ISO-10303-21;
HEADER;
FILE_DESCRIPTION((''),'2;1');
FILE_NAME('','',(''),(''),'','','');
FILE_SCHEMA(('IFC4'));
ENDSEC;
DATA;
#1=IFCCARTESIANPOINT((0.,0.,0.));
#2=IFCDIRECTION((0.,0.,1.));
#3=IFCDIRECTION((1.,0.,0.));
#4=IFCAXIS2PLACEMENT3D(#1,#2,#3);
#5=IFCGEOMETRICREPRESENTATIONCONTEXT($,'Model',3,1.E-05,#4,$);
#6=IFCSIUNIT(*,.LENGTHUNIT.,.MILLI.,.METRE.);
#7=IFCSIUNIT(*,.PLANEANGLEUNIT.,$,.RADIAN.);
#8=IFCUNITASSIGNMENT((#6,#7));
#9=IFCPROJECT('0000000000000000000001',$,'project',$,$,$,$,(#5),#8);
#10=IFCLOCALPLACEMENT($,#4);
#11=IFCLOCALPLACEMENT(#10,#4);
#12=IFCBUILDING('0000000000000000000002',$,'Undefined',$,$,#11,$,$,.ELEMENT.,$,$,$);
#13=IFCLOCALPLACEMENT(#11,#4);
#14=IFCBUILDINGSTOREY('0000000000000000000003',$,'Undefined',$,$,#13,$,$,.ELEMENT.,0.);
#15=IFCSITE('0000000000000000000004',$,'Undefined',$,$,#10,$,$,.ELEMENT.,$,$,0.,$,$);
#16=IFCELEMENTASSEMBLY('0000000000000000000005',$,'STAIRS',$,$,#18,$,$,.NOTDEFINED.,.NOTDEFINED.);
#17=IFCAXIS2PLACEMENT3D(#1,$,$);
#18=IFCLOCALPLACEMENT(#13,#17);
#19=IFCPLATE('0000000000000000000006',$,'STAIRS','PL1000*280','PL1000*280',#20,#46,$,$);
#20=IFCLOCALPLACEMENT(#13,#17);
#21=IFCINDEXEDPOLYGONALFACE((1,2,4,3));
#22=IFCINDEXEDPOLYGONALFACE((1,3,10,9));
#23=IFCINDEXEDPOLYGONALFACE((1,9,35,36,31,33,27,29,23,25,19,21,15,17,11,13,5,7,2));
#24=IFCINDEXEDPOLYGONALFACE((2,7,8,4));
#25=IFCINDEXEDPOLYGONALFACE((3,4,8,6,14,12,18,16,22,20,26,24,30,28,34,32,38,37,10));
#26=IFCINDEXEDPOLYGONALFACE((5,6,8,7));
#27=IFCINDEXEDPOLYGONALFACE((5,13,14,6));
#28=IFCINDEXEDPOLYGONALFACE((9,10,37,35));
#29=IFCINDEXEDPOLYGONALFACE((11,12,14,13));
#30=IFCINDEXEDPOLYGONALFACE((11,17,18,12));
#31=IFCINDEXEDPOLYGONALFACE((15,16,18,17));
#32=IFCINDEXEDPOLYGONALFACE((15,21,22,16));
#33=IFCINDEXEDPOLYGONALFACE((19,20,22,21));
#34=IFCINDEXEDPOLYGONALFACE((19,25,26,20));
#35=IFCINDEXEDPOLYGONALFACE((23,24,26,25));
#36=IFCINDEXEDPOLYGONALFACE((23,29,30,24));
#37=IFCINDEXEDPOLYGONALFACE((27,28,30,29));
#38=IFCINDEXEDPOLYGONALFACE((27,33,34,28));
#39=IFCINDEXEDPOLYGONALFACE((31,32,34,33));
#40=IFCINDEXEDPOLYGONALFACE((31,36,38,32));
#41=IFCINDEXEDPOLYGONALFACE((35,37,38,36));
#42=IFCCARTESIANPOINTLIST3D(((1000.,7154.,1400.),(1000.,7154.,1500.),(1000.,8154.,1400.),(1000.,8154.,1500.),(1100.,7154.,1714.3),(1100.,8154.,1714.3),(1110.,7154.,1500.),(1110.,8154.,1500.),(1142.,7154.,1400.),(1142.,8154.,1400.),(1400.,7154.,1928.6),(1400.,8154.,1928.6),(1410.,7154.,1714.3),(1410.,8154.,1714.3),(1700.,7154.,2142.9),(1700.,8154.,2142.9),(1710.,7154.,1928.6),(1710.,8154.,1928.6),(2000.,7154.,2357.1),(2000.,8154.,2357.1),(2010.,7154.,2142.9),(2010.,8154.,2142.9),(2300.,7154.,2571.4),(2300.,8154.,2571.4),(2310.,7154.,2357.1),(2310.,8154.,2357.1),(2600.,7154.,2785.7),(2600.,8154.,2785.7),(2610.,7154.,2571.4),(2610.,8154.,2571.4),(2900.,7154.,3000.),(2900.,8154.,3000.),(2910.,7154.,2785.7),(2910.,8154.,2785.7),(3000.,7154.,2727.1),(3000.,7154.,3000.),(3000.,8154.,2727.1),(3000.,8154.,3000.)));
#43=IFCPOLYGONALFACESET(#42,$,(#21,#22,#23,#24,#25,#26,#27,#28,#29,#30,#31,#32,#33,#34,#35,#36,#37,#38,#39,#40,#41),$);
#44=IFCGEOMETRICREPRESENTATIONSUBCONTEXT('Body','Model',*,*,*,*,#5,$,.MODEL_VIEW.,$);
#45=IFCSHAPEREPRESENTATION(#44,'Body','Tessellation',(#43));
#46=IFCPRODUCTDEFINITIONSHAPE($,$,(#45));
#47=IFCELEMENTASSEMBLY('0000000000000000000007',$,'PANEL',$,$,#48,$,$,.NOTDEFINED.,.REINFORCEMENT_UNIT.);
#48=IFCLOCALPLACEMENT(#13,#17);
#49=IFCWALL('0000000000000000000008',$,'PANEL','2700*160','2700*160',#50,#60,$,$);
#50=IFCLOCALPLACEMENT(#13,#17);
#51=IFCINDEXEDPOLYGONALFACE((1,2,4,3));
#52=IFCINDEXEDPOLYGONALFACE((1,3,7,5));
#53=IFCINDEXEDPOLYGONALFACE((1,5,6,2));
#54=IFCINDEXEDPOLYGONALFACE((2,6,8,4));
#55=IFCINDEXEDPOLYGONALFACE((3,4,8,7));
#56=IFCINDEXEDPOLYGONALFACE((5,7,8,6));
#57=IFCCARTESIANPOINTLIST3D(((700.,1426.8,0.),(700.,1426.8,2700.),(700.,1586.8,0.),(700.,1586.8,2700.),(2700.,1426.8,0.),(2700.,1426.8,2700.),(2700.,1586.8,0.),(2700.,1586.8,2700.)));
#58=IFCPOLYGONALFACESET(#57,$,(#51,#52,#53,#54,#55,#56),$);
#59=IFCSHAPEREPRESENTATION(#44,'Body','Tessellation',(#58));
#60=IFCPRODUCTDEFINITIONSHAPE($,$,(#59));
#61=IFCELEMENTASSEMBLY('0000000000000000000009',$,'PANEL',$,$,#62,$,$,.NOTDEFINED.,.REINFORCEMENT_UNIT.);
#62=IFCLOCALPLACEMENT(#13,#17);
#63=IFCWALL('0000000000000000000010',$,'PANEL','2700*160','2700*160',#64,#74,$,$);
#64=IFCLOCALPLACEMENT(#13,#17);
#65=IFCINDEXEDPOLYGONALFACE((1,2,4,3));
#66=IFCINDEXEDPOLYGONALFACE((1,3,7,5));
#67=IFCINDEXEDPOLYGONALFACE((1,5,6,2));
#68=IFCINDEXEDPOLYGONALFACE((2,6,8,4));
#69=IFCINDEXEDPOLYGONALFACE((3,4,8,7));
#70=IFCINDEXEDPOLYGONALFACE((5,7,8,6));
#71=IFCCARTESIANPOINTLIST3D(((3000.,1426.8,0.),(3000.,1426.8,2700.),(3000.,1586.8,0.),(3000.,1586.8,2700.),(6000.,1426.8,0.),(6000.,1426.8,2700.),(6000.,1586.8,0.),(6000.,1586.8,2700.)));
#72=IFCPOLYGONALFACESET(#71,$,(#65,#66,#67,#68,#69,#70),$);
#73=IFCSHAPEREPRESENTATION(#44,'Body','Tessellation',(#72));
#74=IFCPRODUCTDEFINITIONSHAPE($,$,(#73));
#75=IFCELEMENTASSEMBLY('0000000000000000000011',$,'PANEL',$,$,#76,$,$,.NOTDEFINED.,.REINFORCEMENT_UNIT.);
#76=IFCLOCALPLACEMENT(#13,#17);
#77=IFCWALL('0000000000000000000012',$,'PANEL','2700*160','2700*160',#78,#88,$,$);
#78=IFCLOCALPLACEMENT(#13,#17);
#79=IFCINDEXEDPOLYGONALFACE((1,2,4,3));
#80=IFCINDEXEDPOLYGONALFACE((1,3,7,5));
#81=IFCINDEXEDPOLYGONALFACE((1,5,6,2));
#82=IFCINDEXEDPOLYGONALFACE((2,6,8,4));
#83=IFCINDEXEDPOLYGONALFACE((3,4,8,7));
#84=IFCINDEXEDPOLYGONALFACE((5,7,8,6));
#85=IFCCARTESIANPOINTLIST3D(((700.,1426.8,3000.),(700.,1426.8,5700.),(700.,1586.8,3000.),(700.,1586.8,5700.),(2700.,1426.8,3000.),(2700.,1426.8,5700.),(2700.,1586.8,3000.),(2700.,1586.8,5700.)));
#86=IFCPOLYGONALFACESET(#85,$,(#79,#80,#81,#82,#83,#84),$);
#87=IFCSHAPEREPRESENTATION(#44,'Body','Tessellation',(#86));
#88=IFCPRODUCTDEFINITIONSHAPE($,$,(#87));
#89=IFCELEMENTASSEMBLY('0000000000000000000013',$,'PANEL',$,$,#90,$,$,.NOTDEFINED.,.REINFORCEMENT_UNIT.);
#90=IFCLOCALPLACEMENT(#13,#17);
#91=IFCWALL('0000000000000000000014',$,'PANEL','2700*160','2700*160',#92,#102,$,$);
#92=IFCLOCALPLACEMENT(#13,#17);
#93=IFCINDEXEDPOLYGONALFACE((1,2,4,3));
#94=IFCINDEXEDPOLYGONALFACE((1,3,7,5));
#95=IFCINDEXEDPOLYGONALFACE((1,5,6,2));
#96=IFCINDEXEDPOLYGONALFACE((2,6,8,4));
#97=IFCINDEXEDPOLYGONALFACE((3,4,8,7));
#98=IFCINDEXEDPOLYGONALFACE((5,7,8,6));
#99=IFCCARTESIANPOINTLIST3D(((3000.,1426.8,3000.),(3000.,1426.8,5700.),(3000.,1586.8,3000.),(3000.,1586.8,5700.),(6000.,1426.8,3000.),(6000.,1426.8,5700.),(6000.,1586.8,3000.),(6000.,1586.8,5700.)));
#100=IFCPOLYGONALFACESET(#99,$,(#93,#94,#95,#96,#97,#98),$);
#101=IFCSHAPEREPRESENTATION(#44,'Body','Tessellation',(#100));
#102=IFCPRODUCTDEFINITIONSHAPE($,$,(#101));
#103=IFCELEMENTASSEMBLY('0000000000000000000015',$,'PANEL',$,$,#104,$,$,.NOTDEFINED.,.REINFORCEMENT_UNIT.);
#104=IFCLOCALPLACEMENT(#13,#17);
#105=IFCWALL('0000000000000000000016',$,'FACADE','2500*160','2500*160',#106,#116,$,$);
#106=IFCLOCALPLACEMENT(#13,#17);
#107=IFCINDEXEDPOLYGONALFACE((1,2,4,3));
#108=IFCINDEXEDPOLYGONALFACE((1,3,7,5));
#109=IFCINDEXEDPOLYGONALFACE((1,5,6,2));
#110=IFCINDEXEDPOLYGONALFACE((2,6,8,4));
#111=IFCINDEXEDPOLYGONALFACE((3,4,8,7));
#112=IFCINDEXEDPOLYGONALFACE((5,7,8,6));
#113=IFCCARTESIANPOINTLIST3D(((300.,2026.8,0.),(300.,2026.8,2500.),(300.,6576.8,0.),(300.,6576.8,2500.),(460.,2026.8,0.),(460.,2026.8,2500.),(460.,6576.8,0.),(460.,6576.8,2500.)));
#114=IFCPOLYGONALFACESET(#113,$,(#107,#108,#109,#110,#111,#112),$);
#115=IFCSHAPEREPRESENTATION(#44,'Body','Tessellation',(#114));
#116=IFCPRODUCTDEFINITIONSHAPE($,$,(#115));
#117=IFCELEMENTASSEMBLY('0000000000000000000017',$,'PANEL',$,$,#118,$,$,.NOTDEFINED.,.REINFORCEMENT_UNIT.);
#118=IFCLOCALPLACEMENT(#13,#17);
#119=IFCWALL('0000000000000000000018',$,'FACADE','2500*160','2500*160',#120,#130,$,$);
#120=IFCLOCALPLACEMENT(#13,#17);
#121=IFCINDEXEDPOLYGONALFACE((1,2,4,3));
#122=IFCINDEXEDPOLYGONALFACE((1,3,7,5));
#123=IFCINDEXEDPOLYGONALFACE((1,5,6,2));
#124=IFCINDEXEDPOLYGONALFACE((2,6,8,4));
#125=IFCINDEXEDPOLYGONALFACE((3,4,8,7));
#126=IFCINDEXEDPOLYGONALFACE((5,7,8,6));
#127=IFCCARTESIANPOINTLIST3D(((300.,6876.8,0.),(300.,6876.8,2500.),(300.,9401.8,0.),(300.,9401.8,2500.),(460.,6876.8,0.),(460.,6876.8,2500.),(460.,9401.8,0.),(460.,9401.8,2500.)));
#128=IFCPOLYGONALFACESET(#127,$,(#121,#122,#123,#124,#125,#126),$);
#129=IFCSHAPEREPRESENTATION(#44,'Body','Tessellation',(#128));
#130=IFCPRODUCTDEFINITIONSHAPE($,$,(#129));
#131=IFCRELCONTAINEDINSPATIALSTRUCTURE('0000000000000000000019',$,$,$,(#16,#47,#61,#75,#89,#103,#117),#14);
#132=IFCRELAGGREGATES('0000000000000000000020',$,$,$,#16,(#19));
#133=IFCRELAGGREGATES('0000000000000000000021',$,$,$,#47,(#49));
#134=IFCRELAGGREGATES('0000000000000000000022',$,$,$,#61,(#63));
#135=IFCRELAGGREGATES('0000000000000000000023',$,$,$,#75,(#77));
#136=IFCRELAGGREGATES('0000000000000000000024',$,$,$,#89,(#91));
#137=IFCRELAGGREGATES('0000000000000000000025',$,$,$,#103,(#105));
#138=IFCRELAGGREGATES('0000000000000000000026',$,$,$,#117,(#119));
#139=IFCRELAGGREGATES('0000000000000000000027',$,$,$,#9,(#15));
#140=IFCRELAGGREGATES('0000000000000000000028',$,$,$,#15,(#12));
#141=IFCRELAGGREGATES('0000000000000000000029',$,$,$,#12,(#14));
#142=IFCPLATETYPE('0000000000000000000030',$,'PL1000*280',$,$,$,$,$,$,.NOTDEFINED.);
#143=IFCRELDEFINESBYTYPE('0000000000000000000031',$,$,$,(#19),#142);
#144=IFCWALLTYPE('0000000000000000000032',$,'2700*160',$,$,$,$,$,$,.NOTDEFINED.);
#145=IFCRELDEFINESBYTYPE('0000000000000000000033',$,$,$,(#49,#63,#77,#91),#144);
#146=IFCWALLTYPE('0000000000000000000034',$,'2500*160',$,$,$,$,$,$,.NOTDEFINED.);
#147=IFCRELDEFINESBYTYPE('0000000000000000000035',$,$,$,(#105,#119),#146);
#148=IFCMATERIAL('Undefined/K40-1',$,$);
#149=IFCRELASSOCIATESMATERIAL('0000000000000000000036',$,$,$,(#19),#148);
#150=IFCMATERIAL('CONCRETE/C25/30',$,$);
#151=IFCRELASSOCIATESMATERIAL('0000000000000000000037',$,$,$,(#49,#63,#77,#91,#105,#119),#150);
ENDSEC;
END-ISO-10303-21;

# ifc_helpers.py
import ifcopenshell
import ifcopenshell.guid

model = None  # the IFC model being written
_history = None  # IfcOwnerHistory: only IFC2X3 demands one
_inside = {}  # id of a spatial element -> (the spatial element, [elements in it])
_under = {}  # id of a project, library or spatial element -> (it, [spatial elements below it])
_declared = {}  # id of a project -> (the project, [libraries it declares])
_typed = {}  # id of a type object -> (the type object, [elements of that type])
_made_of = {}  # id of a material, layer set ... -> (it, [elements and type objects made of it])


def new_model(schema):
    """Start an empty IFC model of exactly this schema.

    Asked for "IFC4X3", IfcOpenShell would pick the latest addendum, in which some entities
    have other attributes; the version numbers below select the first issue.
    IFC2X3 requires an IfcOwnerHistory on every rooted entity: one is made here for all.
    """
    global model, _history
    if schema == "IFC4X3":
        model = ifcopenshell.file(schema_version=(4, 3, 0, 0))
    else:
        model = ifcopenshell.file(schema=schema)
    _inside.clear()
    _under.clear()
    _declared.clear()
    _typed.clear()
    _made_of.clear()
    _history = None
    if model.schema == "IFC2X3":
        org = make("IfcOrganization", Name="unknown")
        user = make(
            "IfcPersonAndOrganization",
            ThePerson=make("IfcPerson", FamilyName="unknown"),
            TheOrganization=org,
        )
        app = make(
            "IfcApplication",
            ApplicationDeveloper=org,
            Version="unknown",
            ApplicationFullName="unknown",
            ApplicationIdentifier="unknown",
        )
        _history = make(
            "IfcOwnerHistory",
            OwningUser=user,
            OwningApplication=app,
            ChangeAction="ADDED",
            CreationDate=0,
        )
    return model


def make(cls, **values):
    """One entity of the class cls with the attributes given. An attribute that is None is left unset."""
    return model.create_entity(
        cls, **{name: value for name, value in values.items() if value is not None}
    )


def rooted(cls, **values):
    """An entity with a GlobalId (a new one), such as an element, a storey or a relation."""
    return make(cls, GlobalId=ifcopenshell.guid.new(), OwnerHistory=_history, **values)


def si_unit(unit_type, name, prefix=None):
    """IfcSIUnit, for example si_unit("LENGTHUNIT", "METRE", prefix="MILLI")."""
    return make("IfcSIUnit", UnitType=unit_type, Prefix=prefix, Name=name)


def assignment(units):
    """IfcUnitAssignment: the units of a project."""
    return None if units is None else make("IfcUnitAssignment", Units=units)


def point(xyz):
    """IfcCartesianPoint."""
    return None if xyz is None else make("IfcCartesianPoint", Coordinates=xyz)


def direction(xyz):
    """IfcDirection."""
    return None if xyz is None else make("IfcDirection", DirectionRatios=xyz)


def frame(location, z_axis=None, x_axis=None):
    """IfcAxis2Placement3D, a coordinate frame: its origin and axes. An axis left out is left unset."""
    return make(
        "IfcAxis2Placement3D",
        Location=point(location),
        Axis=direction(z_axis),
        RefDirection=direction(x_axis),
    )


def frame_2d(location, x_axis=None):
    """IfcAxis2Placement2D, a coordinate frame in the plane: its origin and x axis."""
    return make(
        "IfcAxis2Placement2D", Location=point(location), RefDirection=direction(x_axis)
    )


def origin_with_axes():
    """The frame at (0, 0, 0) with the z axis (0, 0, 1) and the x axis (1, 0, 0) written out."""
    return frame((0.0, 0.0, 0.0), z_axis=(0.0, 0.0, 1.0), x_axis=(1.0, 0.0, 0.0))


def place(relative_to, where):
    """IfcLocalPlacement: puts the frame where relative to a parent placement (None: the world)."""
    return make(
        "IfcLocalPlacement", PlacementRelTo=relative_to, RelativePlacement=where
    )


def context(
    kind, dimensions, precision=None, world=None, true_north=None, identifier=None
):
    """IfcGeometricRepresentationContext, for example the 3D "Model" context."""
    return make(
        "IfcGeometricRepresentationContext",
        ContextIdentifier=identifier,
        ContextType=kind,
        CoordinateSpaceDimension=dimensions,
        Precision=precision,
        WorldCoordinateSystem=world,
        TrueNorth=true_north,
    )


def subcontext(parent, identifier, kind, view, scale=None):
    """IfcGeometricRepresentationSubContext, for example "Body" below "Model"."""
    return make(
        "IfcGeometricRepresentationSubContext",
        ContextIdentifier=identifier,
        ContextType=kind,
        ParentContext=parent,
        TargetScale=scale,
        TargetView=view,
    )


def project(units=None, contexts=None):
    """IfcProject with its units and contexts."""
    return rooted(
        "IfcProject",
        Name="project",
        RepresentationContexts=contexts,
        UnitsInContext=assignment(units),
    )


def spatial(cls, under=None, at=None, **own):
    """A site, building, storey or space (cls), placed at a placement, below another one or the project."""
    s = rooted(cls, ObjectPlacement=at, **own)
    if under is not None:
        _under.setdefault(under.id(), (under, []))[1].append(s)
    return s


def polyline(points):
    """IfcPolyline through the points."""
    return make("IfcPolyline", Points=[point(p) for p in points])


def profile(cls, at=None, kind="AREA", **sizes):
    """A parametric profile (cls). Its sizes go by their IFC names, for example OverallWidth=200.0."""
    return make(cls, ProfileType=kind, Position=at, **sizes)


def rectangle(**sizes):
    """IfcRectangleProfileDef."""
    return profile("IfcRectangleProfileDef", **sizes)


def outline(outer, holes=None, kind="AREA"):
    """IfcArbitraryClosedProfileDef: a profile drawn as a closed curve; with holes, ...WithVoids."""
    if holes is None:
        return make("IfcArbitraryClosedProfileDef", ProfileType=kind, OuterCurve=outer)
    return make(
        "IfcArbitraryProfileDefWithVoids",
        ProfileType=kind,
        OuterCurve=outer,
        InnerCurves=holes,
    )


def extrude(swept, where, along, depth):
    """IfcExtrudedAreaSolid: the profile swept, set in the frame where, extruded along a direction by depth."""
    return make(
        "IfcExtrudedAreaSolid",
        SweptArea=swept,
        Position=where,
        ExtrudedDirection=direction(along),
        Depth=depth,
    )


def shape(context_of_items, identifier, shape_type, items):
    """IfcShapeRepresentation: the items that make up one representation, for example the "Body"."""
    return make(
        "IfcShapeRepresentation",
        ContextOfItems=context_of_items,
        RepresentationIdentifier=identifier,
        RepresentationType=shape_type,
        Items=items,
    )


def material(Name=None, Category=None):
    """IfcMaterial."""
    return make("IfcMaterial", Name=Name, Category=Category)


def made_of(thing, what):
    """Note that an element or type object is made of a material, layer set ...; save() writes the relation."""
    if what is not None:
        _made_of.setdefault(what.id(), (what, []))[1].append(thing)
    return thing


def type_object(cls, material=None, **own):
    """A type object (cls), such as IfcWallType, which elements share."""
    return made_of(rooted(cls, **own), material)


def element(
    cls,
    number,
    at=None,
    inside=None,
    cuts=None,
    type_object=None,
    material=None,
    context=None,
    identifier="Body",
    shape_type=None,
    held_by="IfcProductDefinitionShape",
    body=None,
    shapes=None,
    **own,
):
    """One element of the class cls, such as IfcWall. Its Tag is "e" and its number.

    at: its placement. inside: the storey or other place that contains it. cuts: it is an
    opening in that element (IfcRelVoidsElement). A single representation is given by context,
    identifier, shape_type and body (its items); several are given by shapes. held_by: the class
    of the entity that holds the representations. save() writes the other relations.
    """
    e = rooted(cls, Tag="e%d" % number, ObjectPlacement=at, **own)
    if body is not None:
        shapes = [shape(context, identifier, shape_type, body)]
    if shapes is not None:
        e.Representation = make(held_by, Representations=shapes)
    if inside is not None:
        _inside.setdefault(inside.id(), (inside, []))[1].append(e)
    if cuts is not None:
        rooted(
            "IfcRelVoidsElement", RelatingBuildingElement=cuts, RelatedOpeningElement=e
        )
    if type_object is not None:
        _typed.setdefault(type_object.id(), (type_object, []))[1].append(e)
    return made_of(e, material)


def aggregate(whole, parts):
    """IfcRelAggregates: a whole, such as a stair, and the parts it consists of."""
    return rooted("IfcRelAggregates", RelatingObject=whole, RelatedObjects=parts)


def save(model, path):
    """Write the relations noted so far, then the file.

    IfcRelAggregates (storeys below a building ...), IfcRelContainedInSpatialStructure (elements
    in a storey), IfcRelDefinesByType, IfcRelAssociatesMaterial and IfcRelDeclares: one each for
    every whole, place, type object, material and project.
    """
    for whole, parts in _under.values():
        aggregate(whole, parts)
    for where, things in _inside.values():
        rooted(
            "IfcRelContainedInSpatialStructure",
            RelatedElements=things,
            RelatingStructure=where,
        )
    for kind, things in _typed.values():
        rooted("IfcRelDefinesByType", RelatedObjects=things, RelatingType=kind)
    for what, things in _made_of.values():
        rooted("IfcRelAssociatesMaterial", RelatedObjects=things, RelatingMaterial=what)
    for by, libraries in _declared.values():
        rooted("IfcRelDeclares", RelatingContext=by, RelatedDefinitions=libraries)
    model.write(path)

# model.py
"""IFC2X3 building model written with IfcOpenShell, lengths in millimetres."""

from ifc_helpers import new_model, si_unit, frame, frame_2d, origin_with_axes, place, context, subcontext, project, spatial, polyline, rectangle, outline, extrude, material, type_object, element, aggregate, save


model = new_model("IFC2X3")

# Units and contexts
model_context = context("Model", 3, precision=1e-05, world=origin_with_axes())
body_context = subcontext(model_context, "Body", "Model", "MODEL_VIEW")
ifc_project = project(units=[si_unit("LENGTHUNIT", "METRE", prefix="MILLI"), si_unit("PLANEANGLEUNIT", "RADIAN")], contexts=[model_context])

# Site, building, storey
site_placement = place(None, origin_with_axes())
site = spatial("IfcSite", under=ifc_project, at=site_placement, Name="Undefined", CompositionType="ELEMENT", RefElevation=0.0)
building_placement = place(site_placement, origin_with_axes())
building = spatial("IfcBuilding", under=site, at=building_placement, Name="Undefined", CompositionType="ELEMENT")
storey_placement = place(building_placement, origin_with_axes())
storey = spatial("IfcBuildingStorey", under=building, at=storey_placement, Name="Undefined", CompositionType="ELEMENT", Elevation=0.0)

# Shared definitions
ifc_material_1 = material(Name="CONCRETE/C25/30")

# Element assembly, plate
ifc_material_2 = material(Name="Undefined/K40-1")
assembly_1_placement = place(storey_placement, origin_with_axes())
assembly_1 = element("IfcElementAssembly", 1, at=assembly_1_placement, inside=storey, Name="STAIRS", AssemblyPlace="NOTDEFINED", PredefinedType="NOTDEFINED")
plate_type_1 = type_object("IfcPlateType", Name="PL1000*280", PredefinedType="NOTDEFINED")
plate_1_placement = place(assembly_1_placement, frame((1110.0, 7654.0, 1500.0), z_axis=(0.0, -1.0, 0.0), x_axis=(-1.0, 0.0, 0.0)))
plate_1 = element("IfcPlate", 2, at=plate_1_placement, type_object=plate_type_1, material=ifc_material_2, Name="STAIRS", Description="PL1000*280", ObjectType="PL1000*280", context=body_context, shape_type="SweptSolid", body=[
    extrude(outline(polyline([(0.0, 0.0), (110.0, 0.0), (110.0, 100.0), (-32.0, 100.0), (-1890.0, -1227.1), (-1890.0, -1500.0), (-1790.0, -1500.0), (-1800.0, -1285.7), (-1490.0, -1285.7), (-1500.0, -1071.4), (-1190.0, -1071.4), (-1200.0, -857.1), (-890.0, -857.1), (-900.0, -642.9), (-590.0, -642.9), (-600.0, -428.6), (-290.0, -428.6), (-300.0, -214.3), (10.0, -214.3), (0.0, 0.0), (0.0, 0.0)])), frame((0.0, 0.0, -500.0), z_axis=(0.0, 0.0, 1.0), x_axis=(1.0, 0.0, 0.0)), (0.0, 0.0, 1.0), 1000.0),
])
aggregate(assembly_1, [plate_1])

# Element assemblies, walls
assembly_2_placement = place(storey_placement, origin_with_axes())
assembly_2 = element("IfcElementAssembly", 3, at=assembly_2_placement, inside=storey, Name="PANEL", AssemblyPlace="NOTDEFINED", PredefinedType="REINFORCEMENT_UNIT")
wall_type_1 = type_object("IfcWallType", Name="2700*160", PredefinedType="NOTDEFINED")
wall_1_placement = place(assembly_2_placement, frame((700.0, 1506.8, 0.0), z_axis=(0.0, 0.0, 1.0), x_axis=(1.0, 0.0, 0.0)))
wall_1 = element("IfcWall", 4, at=wall_1_placement, type_object=wall_type_1, material=ifc_material_1, Name="PANEL", Description="2700*160", ObjectType="2700*160", context=body_context, shape_type="SweptSolid", body=[
    extrude(rectangle(XDim=2000.0, YDim=160.0, at=frame_2d((0.0, 1000.0), x_axis=(0.0, -1.0))), frame((0.0, 0.0, 0.0), z_axis=(0.0, 0.0, 1.0), x_axis=(0.0, -1.0, 0.0)), (0.0, 0.0, 1.0), 2700.0),
])
aggregate(assembly_2, [wall_1])
assembly_3_placement = place(storey_placement, origin_with_axes())
assembly_3 = element("IfcElementAssembly", 5, at=assembly_3_placement, inside=storey, Name="PANEL", AssemblyPlace="NOTDEFINED", PredefinedType="REINFORCEMENT_UNIT")
wall_2_placement = place(assembly_3_placement, frame((3000.0, 1506.8, 0.0), z_axis=(0.0, 0.0, 1.0), x_axis=(1.0, 0.0, 0.0)))
wall_2 = element("IfcWall", 6, at=wall_2_placement, type_object=wall_type_1, material=ifc_material_1, Name="PANEL", Description="2700*160", ObjectType="2700*160", context=body_context, shape_type="SweptSolid", body=[
    extrude(rectangle(XDim=3000.0, YDim=160.0, at=frame_2d((0.0, 1500.0), x_axis=(0.0, -1.0))), frame((0.0, 0.0, 0.0), z_axis=(0.0, 0.0, 1.0), x_axis=(0.0, -1.0, 0.0)), (0.0, 0.0, 1.0), 2700.0),
])
aggregate(assembly_3, [wall_2])
assembly_4_placement = place(storey_placement, origin_with_axes())
assembly_4 = element("IfcElementAssembly", 7, at=assembly_4_placement, inside=storey, Name="PANEL", AssemblyPlace="NOTDEFINED", PredefinedType="REINFORCEMENT_UNIT")
wall_3_placement = place(assembly_4_placement, frame((700.0, 1506.8, 3000.0), z_axis=(0.0, 0.0, 1.0), x_axis=(1.0, 0.0, 0.0)))
wall_3 = element("IfcWall", 8, at=wall_3_placement, type_object=wall_type_1, material=ifc_material_1, Name="PANEL", Description="2700*160", ObjectType="2700*160", context=body_context, shape_type="SweptSolid", body=[
    extrude(rectangle(XDim=2000.0, YDim=160.0, at=frame_2d((0.0, 1000.0), x_axis=(0.0, -1.0))), frame((0.0, 0.0, 0.0), z_axis=(0.0, 0.0, 1.0), x_axis=(0.0, -1.0, 0.0)), (0.0, 0.0, 1.0), 2700.0),
])
aggregate(assembly_4, [wall_3])
assembly_5_placement = place(storey_placement, origin_with_axes())
assembly_5 = element("IfcElementAssembly", 9, at=assembly_5_placement, inside=storey, Name="PANEL", AssemblyPlace="NOTDEFINED", PredefinedType="REINFORCEMENT_UNIT")
wall_4_placement = place(assembly_5_placement, frame((3000.0, 1506.8, 3000.0), z_axis=(0.0, 0.0, 1.0), x_axis=(1.0, 0.0, 0.0)))
wall_4 = element("IfcWall", 10, at=wall_4_placement, type_object=wall_type_1, material=ifc_material_1, Name="PANEL", Description="2700*160", ObjectType="2700*160", context=body_context, shape_type="SweptSolid", body=[
    extrude(rectangle(XDim=3000.0, YDim=160.0, at=frame_2d((0.0, 1500.0), x_axis=(0.0, -1.0))), frame((0.0, 0.0, 0.0), z_axis=(0.0, 0.0, 1.0), x_axis=(0.0, -1.0, 0.0)), (0.0, 0.0, 1.0), 2700.0),
])
aggregate(assembly_5, [wall_4])
assembly_6_placement = place(storey_placement, origin_with_axes())
assembly_6 = element("IfcElementAssembly", 11, at=assembly_6_placement, inside=storey, Name="PANEL", AssemblyPlace="NOTDEFINED", PredefinedType="REINFORCEMENT_UNIT")
wall_type_2 = type_object("IfcWallType", Name="2500*160", PredefinedType="NOTDEFINED")
wall_5_placement = place(assembly_6_placement, frame((380.0, 6576.8, 0.0), z_axis=(0.0, 0.0, 1.0), x_axis=(0.0, -1.0, 0.0)))
wall_5 = element("IfcWall", 12, at=wall_5_placement, type_object=wall_type_2, material=ifc_material_1, Name="FACADE", Description="2500*160", ObjectType="2500*160", context=body_context, shape_type="SweptSolid", body=[
    extrude(rectangle(XDim=4550.0, YDim=160.0, at=frame_2d((0.0, 2275.0), x_axis=(0.0, -1.0))), frame((0.0, 0.0, 0.0), z_axis=(0.0, 0.0, 1.0), x_axis=(0.0, -1.0, 0.0)), (0.0, 0.0, 1.0), 2500.0),
])
aggregate(assembly_6, [wall_5])
assembly_7_placement = place(storey_placement, origin_with_axes())
assembly_7 = element("IfcElementAssembly", 13, at=assembly_7_placement, inside=storey, Name="PANEL", AssemblyPlace="NOTDEFINED", PredefinedType="REINFORCEMENT_UNIT")
wall_6_placement = place(assembly_7_placement, frame((380.0, 9401.8, 0.0), z_axis=(0.0, 0.0, 1.0), x_axis=(0.0, -1.0, 0.0)))
wall_6 = element("IfcWall", 14, at=wall_6_placement, type_object=wall_type_2, material=ifc_material_1, Name="FACADE", Description="2500*160", ObjectType="2500*160", context=body_context, shape_type="SweptSolid", body=[
    extrude(rectangle(XDim=2525.0, YDim=160.0, at=frame_2d((0.0, 1262.5), x_axis=(0.0, -1.0))), frame((0.0, 0.0, 0.0), z_axis=(0.0, 0.0, 1.0), x_axis=(0.0, -1.0, 0.0)), (0.0, 0.0, 1.0), 2500.0),
])
aggregate(assembly_7, [wall_6])

save(model, "model.ifc")
